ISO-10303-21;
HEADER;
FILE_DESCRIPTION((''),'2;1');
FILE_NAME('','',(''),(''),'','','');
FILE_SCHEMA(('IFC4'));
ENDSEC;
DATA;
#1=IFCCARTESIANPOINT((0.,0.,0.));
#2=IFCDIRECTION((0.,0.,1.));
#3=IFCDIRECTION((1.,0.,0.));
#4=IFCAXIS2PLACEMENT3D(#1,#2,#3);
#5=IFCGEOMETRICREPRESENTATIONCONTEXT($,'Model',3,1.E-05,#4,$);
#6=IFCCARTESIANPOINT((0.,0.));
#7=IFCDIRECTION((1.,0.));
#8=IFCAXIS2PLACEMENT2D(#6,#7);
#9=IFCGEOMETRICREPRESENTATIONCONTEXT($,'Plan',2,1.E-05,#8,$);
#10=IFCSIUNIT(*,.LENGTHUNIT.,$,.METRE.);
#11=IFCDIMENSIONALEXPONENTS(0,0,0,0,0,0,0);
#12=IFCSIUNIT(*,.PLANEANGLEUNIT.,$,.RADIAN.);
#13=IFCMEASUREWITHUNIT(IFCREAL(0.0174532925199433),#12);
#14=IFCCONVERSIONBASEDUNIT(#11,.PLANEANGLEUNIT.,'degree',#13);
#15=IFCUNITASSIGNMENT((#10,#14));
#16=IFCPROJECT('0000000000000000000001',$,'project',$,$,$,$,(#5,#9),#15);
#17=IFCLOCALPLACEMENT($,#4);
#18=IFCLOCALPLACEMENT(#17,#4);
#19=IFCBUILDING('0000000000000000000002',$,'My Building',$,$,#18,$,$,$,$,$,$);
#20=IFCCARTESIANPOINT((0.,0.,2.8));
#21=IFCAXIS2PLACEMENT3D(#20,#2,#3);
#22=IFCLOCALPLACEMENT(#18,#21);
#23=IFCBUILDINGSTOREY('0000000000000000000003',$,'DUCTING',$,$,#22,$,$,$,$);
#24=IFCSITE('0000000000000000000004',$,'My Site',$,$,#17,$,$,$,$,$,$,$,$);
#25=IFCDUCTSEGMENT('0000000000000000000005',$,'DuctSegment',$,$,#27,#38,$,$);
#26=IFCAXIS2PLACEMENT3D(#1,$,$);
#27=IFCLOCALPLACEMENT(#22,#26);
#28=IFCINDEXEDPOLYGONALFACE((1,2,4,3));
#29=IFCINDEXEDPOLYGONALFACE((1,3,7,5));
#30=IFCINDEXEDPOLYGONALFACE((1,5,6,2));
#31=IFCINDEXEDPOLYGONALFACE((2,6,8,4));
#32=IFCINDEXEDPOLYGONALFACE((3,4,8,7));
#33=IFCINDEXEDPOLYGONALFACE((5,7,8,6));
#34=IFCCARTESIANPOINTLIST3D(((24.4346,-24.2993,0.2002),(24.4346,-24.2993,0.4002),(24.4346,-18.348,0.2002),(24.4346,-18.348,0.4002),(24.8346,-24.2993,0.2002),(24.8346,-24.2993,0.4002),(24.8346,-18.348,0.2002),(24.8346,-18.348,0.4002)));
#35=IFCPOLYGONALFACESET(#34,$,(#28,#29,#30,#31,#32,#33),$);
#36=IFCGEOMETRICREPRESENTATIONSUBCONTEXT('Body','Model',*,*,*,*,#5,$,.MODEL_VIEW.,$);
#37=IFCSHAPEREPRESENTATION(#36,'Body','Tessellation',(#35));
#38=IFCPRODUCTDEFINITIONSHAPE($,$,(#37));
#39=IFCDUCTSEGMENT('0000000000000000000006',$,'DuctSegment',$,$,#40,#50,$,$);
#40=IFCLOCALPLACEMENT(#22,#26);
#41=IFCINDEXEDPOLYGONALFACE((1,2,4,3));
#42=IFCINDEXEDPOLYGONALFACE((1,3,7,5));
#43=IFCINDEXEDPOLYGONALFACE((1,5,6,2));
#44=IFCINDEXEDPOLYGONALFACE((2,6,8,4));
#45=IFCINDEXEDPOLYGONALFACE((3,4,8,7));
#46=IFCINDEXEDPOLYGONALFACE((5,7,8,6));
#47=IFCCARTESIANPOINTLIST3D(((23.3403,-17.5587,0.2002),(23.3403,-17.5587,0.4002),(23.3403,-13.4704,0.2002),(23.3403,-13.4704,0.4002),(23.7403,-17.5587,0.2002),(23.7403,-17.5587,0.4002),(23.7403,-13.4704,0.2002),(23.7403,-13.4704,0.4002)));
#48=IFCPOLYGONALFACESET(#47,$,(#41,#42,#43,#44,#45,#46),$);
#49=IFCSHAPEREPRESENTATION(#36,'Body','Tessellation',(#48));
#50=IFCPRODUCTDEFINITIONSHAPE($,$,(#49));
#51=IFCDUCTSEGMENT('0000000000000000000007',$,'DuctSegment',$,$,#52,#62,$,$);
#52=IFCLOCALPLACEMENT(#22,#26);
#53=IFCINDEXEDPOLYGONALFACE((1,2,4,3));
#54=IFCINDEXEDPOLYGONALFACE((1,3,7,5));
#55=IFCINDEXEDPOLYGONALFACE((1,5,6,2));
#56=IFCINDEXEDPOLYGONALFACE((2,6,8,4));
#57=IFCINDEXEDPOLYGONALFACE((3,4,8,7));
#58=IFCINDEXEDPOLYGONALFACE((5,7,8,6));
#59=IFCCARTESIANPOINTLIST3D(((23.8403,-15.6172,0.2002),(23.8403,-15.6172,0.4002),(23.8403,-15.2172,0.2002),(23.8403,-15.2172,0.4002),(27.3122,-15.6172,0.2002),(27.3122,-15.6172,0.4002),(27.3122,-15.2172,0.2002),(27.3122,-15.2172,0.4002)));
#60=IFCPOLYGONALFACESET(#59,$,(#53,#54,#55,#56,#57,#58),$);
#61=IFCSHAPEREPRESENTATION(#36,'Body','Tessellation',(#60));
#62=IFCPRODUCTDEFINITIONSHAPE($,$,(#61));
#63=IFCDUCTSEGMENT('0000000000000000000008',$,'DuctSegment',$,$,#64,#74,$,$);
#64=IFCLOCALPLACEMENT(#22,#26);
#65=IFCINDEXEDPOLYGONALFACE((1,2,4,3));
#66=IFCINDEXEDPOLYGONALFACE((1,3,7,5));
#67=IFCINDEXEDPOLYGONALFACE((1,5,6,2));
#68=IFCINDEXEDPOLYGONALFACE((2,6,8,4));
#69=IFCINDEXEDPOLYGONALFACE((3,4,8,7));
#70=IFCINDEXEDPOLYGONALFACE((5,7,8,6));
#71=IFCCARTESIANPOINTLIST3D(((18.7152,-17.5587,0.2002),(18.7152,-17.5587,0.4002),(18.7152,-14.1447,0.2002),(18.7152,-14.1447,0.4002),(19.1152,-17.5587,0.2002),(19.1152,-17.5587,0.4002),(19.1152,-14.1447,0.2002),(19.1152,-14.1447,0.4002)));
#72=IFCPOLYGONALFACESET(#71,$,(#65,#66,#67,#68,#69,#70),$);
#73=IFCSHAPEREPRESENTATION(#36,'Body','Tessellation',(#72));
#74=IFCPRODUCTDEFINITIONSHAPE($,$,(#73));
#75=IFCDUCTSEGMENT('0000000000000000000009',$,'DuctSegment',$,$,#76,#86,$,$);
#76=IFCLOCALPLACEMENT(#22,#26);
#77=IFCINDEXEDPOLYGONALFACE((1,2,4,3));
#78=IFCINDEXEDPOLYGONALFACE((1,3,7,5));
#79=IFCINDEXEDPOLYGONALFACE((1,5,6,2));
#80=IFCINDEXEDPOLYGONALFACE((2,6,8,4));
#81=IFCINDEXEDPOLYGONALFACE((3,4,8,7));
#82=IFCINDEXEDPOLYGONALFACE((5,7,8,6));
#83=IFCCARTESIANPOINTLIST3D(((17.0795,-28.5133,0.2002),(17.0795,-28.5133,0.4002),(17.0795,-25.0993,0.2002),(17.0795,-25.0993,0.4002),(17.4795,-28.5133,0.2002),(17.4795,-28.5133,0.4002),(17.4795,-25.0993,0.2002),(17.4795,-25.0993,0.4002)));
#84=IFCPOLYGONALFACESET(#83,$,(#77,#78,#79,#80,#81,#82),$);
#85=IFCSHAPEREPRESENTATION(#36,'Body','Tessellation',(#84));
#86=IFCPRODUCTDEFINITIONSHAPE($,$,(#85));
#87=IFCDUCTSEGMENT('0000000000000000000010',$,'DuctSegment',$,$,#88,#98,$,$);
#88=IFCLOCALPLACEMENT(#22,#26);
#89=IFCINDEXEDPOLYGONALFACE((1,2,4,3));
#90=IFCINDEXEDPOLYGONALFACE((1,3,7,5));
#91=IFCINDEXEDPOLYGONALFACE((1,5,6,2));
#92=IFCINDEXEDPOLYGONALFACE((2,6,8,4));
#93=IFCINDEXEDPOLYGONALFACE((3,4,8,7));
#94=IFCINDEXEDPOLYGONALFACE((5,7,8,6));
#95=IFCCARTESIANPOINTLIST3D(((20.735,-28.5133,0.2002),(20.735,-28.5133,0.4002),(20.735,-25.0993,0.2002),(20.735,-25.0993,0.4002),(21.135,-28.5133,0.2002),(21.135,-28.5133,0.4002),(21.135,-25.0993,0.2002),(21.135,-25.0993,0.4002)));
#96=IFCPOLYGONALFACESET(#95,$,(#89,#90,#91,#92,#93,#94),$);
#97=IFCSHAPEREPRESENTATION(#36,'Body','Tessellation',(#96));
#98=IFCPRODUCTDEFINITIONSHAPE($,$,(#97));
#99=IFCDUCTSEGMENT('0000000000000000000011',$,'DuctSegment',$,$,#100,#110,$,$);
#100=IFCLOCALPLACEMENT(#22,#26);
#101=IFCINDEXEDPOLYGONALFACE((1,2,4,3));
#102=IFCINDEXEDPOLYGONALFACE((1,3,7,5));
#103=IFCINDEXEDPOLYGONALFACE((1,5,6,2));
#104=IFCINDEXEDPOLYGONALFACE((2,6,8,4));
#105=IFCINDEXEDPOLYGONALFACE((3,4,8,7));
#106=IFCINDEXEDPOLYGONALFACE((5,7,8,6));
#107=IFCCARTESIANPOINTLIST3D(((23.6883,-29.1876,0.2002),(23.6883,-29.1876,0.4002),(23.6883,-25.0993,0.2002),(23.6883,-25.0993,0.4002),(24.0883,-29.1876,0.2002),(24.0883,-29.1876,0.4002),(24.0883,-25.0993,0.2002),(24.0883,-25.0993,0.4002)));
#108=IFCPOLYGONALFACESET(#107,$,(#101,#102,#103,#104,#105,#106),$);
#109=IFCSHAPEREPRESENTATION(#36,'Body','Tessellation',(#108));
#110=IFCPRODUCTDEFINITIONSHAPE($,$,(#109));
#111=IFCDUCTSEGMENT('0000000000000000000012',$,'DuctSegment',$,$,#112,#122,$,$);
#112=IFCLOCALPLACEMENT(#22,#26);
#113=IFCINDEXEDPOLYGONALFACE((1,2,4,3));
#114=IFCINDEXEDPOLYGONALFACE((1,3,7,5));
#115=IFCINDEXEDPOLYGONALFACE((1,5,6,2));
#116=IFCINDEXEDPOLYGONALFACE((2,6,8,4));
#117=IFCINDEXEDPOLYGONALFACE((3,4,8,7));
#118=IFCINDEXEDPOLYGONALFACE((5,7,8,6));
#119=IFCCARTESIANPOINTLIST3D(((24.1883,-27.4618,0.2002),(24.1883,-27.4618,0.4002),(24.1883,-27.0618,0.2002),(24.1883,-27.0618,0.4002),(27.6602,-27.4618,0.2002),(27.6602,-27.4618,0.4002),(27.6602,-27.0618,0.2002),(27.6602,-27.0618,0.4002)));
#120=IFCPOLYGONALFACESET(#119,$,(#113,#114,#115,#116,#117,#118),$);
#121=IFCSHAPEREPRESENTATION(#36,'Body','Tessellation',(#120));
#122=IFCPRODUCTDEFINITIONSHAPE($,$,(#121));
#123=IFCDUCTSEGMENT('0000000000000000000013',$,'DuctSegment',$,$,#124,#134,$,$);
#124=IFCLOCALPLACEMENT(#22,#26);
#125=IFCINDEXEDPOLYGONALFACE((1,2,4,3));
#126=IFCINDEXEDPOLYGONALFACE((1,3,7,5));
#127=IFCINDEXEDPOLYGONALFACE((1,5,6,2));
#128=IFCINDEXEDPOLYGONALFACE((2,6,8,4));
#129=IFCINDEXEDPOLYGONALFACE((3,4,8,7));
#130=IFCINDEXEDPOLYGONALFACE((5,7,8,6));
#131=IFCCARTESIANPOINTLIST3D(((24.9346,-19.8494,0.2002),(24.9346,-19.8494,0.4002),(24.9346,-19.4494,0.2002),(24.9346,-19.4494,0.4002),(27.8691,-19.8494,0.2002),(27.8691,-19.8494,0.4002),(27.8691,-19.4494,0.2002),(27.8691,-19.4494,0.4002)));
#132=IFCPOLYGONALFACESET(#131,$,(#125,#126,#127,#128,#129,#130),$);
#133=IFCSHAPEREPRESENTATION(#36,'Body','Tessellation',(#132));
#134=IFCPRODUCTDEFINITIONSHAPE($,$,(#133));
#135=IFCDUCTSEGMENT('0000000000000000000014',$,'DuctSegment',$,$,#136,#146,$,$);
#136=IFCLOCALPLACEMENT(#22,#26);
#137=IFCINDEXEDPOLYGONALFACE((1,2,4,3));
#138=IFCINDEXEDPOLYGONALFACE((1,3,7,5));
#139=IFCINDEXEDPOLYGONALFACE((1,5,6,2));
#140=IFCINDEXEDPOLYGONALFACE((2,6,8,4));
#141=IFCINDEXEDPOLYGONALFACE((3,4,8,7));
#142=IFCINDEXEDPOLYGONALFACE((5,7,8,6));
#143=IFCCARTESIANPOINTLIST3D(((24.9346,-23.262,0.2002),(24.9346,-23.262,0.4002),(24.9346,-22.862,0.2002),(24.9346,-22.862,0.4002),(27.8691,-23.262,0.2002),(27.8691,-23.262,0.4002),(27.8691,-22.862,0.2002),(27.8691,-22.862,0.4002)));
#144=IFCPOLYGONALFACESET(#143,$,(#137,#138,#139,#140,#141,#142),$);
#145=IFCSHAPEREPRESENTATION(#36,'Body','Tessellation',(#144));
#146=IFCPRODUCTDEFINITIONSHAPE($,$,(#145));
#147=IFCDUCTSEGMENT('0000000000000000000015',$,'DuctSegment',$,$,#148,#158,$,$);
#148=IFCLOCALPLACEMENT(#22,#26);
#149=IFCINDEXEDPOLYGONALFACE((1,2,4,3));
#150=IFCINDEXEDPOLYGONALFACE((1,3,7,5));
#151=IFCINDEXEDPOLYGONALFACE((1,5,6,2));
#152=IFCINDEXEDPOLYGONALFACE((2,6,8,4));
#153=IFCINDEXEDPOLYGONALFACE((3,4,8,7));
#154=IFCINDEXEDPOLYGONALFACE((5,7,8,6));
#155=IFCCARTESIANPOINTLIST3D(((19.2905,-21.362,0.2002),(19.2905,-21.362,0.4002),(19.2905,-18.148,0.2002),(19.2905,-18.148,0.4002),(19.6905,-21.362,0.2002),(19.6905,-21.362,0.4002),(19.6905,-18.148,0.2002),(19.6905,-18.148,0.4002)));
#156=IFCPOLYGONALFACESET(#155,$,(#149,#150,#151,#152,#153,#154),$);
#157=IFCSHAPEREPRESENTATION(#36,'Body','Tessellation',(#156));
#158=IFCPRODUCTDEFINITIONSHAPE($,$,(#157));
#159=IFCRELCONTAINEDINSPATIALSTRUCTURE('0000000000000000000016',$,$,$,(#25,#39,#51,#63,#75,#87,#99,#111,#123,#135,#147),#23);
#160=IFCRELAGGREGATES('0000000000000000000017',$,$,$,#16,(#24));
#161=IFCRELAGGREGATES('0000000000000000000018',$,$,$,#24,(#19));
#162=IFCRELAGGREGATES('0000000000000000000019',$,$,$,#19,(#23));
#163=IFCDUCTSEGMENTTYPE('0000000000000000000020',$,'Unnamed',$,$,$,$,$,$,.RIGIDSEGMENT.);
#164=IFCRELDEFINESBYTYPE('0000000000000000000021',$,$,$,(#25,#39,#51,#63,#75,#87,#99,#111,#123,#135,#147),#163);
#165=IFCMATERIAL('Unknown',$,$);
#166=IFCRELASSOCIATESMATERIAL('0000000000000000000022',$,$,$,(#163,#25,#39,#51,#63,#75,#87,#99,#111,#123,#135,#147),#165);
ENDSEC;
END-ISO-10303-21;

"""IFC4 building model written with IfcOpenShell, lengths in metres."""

from ifc_helpers import new_model, entity, si_unit, converted_unit, frame, origin_with_axes, origin_2d_with_axis, place, context, subcontext, project, spatial, rectangle, extrude, material, material_profile, profile_set, profile_usage, type_object, element, save


model = new_model("IFC4")

# Units and contexts
model_context = context("Model", 3, precision=1e-05, world=origin_with_axes())
plan_context = context("Plan", 2, precision=1e-05, world=origin_2d_with_axis())
body_context = subcontext(model_context, "Body", "Model", "MODEL_VIEW")
ifc_project = project(units=[si_unit("LENGTHUNIT", "METRE"), converted_unit("PLANEANGLEUNIT", "degree", entity("IfcReal", 0.0174532925199433), si_unit("PLANEANGLEUNIT", "RADIAN"), dimensions=[0, 0, 0, 0, 0, 0, 0])], contexts=[model_context, plan_context])

# Site, building, storey
site_placement = place(None, origin_with_axes())
site = spatial("IfcSite", under=ifc_project, at=site_placement, Name="My Site")
building_placement = place(site_placement, origin_with_axes())
building = spatial("IfcBuilding", under=site, at=building_placement, Name="My Building")
storey_placement = place(building_placement, frame((0.0, 0.0, 2.8), z_axis=(0.0, 0.0, 1.0), x_axis=(1.0, 0.0, 0.0)))
storey = spatial("IfcBuildingStorey", under=building, at=storey_placement, Name="DUCTING")

# Duct segments
ifc_material = material(Name="Unknown")
ifc_material_profile_1 = material_profile(ifc_material, rectangle(XDim=0.4, YDim=0.2))
ifc_profile_set_1 = profile_set([ifc_material_profile_1])
ifc_profile_usage_1 = profile_usage(ifc_profile_set_1, cardinal=5)
duct_segment_type = type_object("IfcDuctSegmentType", Name="Unnamed", PredefinedType="RIGIDSEGMENT", material=ifc_profile_set_1)
duct_segment_1_placement = place(storey_placement, frame((24.6346, -18.348, 0.3002), z_axis=(0.0, -1.0, 0.0), x_axis=(1.0, 0.0, 0.0)))
element("IfcDuctSegment", 1, at=duct_segment_1_placement, inside=storey, type_object=duct_segment_type, material=ifc_profile_usage_1, Name="DuctSegment", context=body_context, shape_type="SweptSolid", body=[
    extrude(rectangle(XDim=0.4, YDim=0.2), origin_with_axes(), (0.0, 0.0, 1.0), 5.9513),
])
ifc_profile_usage_2 = profile_usage(ifc_profile_set_1, cardinal=5)
duct_segment_2_placement = place(storey_placement, frame((23.5403, -17.5587, 0.3002), z_axis=(0.0, 1.0, 0.0), x_axis=(-1.0, 0.0, 0.0)))
element("IfcDuctSegment", 2, at=duct_segment_2_placement, inside=storey, type_object=duct_segment_type, material=ifc_profile_usage_2, Name="DuctSegment", context=body_context, shape_type="SweptSolid", body=[
    extrude(rectangle(XDim=0.4, YDim=0.2), origin_with_axes(), (0.0, 0.0, 1.0), 4.0883),
])
ifc_profile_usage_3 = profile_usage(ifc_profile_set_1, cardinal=5)
duct_segment_3_placement = place(storey_placement, frame((23.8403, -15.4172, 0.3002), z_axis=(1.0, 0.0, 0.0), x_axis=(0.0, 1.0, 0.0)))
element("IfcDuctSegment", 3, at=duct_segment_3_placement, inside=storey, type_object=duct_segment_type, material=ifc_profile_usage_3, Name="DuctSegment", context=body_context, shape_type="SweptSolid", body=[
    extrude(rectangle(XDim=0.4, YDim=0.2), origin_with_axes(), (0.0, 0.0, 1.0), 3.4719),
])
ifc_profile_usage_4 = profile_usage(ifc_profile_set_1, cardinal=5)
duct_segment_4_placement = place(storey_placement, frame((18.9152, -17.5587, 0.3002), z_axis=(0.0, 1.0, 0.0), x_axis=(-1.0, 0.0, 0.0)))
element("IfcDuctSegment", 4, at=duct_segment_4_placement, inside=storey, type_object=duct_segment_type, material=ifc_profile_usage_4, Name="DuctSegment", context=body_context, shape_type="SweptSolid", body=[
    extrude(rectangle(XDim=0.4, YDim=0.2), origin_with_axes(), (0.0, 0.0, 1.0), 3.4141),
])
ifc_profile_usage_5 = profile_usage(ifc_profile_set_1, cardinal=5)
duct_segment_5_placement = place(storey_placement, frame((17.2795, -25.0993, 0.3002), z_axis=(0.0, -1.0, 0.0), x_axis=(1.0, 0.0, 0.0)))
element("IfcDuctSegment", 5, at=duct_segment_5_placement, inside=storey, type_object=duct_segment_type, material=ifc_profile_usage_5, Name="DuctSegment", context=body_context, shape_type="SweptSolid", body=[
    extrude(rectangle(XDim=0.4, YDim=0.2), origin_with_axes(), (0.0, 0.0, 1.0), 3.4141),
])
ifc_profile_usage_6 = profile_usage(ifc_profile_set_1, cardinal=5)
duct_segment_6_placement = place(storey_placement, frame((20.935, -25.0993, 0.3002), z_axis=(0.0, -1.0, 0.0), x_axis=(1.0, 0.0, 0.0)))
element("IfcDuctSegment", 6, at=duct_segment_6_placement, inside=storey, type_object=duct_segment_type, material=ifc_profile_usage_6, Name="DuctSegment", context=body_context, shape_type="SweptSolid", body=[
    extrude(rectangle(XDim=0.4, YDim=0.2), origin_with_axes(), (0.0, 0.0, 1.0), 3.4141),
])
ifc_profile_usage_7 = profile_usage(ifc_profile_set_1, cardinal=5)
duct_segment_7_placement = place(storey_placement, frame((23.8883, -25.0993, 0.3002), z_axis=(0.0, -1.0, 0.0), x_axis=(1.0, 0.0, 0.0)))
element("IfcDuctSegment", 7, at=duct_segment_7_placement, inside=storey, type_object=duct_segment_type, material=ifc_profile_usage_7, Name="DuctSegment", context=body_context, shape_type="SweptSolid", body=[
    extrude(rectangle(XDim=0.4, YDim=0.2), origin_with_axes(), (0.0, 0.0, 1.0), 4.0883),
])
ifc_profile_usage_8 = profile_usage(ifc_profile_set_1, cardinal=5)
duct_segment_8_placement = place(storey_placement, frame((24.1883, -27.2618, 0.3002), z_axis=(1.0, 0.0, 0.0), x_axis=(0.0, 1.0, 0.0)))
element("IfcDuctSegment", 8, at=duct_segment_8_placement, inside=storey, type_object=duct_segment_type, material=ifc_profile_usage_8, Name="DuctSegment", context=body_context, shape_type="SweptSolid", body=[
    extrude(rectangle(XDim=0.4, YDim=0.2), origin_with_axes(), (0.0, 0.0, 1.0), 3.4719),
])
ifc_profile_usage_9 = profile_usage(ifc_profile_set_1, cardinal=5)
duct_segment_9_placement = place(storey_placement, frame((24.9346, -19.6494, 0.3002), z_axis=(1.0, 0.0, 0.0), x_axis=(0.0, 1.0, 0.0)))
element("IfcDuctSegment", 9, at=duct_segment_9_placement, inside=storey, type_object=duct_segment_type, material=ifc_profile_usage_9, Name="DuctSegment", context=body_context, shape_type="SweptSolid", body=[
    extrude(rectangle(XDim=0.4, YDim=0.2), origin_with_axes(), (0.0, 0.0, 1.0), 2.9345),
])
ifc_profile_usage_10 = profile_usage(ifc_profile_set_1, cardinal=5)
duct_segment_10_placement = place(storey_placement, frame((24.9346, -23.062, 0.3002), z_axis=(1.0, 0.0, 0.0), x_axis=(0.0, 1.0, 0.0)))
element("IfcDuctSegment", 10, at=duct_segment_10_placement, inside=storey, type_object=duct_segment_type, material=ifc_profile_usage_10, Name="DuctSegment", context=body_context, shape_type="SweptSolid", body=[
    extrude(rectangle(XDim=0.4, YDim=0.2), origin_with_axes(), (0.0, 0.0, 1.0), 2.9345),
])
ifc_profile_usage_11 = profile_usage(ifc_profile_set_1, cardinal=5)
duct_segment_11_placement = place(storey_placement, frame((19.4905, -18.148, 0.3002), z_axis=(0.0, -1.0, 0.0), x_axis=(1.0, 0.0, 0.0)))
element("IfcDuctSegment", 11, at=duct_segment_11_placement, inside=storey, type_object=duct_segment_type, material=ifc_profile_usage_11, Name="DuctSegment", context=body_context, shape_type="SweptSolid", body=[
    extrude(rectangle(XDim=0.4, YDim=0.2), origin_with_axes(), (0.0, 0.0, 1.0), 3.2141),
])

save(model, "model.ifc")
